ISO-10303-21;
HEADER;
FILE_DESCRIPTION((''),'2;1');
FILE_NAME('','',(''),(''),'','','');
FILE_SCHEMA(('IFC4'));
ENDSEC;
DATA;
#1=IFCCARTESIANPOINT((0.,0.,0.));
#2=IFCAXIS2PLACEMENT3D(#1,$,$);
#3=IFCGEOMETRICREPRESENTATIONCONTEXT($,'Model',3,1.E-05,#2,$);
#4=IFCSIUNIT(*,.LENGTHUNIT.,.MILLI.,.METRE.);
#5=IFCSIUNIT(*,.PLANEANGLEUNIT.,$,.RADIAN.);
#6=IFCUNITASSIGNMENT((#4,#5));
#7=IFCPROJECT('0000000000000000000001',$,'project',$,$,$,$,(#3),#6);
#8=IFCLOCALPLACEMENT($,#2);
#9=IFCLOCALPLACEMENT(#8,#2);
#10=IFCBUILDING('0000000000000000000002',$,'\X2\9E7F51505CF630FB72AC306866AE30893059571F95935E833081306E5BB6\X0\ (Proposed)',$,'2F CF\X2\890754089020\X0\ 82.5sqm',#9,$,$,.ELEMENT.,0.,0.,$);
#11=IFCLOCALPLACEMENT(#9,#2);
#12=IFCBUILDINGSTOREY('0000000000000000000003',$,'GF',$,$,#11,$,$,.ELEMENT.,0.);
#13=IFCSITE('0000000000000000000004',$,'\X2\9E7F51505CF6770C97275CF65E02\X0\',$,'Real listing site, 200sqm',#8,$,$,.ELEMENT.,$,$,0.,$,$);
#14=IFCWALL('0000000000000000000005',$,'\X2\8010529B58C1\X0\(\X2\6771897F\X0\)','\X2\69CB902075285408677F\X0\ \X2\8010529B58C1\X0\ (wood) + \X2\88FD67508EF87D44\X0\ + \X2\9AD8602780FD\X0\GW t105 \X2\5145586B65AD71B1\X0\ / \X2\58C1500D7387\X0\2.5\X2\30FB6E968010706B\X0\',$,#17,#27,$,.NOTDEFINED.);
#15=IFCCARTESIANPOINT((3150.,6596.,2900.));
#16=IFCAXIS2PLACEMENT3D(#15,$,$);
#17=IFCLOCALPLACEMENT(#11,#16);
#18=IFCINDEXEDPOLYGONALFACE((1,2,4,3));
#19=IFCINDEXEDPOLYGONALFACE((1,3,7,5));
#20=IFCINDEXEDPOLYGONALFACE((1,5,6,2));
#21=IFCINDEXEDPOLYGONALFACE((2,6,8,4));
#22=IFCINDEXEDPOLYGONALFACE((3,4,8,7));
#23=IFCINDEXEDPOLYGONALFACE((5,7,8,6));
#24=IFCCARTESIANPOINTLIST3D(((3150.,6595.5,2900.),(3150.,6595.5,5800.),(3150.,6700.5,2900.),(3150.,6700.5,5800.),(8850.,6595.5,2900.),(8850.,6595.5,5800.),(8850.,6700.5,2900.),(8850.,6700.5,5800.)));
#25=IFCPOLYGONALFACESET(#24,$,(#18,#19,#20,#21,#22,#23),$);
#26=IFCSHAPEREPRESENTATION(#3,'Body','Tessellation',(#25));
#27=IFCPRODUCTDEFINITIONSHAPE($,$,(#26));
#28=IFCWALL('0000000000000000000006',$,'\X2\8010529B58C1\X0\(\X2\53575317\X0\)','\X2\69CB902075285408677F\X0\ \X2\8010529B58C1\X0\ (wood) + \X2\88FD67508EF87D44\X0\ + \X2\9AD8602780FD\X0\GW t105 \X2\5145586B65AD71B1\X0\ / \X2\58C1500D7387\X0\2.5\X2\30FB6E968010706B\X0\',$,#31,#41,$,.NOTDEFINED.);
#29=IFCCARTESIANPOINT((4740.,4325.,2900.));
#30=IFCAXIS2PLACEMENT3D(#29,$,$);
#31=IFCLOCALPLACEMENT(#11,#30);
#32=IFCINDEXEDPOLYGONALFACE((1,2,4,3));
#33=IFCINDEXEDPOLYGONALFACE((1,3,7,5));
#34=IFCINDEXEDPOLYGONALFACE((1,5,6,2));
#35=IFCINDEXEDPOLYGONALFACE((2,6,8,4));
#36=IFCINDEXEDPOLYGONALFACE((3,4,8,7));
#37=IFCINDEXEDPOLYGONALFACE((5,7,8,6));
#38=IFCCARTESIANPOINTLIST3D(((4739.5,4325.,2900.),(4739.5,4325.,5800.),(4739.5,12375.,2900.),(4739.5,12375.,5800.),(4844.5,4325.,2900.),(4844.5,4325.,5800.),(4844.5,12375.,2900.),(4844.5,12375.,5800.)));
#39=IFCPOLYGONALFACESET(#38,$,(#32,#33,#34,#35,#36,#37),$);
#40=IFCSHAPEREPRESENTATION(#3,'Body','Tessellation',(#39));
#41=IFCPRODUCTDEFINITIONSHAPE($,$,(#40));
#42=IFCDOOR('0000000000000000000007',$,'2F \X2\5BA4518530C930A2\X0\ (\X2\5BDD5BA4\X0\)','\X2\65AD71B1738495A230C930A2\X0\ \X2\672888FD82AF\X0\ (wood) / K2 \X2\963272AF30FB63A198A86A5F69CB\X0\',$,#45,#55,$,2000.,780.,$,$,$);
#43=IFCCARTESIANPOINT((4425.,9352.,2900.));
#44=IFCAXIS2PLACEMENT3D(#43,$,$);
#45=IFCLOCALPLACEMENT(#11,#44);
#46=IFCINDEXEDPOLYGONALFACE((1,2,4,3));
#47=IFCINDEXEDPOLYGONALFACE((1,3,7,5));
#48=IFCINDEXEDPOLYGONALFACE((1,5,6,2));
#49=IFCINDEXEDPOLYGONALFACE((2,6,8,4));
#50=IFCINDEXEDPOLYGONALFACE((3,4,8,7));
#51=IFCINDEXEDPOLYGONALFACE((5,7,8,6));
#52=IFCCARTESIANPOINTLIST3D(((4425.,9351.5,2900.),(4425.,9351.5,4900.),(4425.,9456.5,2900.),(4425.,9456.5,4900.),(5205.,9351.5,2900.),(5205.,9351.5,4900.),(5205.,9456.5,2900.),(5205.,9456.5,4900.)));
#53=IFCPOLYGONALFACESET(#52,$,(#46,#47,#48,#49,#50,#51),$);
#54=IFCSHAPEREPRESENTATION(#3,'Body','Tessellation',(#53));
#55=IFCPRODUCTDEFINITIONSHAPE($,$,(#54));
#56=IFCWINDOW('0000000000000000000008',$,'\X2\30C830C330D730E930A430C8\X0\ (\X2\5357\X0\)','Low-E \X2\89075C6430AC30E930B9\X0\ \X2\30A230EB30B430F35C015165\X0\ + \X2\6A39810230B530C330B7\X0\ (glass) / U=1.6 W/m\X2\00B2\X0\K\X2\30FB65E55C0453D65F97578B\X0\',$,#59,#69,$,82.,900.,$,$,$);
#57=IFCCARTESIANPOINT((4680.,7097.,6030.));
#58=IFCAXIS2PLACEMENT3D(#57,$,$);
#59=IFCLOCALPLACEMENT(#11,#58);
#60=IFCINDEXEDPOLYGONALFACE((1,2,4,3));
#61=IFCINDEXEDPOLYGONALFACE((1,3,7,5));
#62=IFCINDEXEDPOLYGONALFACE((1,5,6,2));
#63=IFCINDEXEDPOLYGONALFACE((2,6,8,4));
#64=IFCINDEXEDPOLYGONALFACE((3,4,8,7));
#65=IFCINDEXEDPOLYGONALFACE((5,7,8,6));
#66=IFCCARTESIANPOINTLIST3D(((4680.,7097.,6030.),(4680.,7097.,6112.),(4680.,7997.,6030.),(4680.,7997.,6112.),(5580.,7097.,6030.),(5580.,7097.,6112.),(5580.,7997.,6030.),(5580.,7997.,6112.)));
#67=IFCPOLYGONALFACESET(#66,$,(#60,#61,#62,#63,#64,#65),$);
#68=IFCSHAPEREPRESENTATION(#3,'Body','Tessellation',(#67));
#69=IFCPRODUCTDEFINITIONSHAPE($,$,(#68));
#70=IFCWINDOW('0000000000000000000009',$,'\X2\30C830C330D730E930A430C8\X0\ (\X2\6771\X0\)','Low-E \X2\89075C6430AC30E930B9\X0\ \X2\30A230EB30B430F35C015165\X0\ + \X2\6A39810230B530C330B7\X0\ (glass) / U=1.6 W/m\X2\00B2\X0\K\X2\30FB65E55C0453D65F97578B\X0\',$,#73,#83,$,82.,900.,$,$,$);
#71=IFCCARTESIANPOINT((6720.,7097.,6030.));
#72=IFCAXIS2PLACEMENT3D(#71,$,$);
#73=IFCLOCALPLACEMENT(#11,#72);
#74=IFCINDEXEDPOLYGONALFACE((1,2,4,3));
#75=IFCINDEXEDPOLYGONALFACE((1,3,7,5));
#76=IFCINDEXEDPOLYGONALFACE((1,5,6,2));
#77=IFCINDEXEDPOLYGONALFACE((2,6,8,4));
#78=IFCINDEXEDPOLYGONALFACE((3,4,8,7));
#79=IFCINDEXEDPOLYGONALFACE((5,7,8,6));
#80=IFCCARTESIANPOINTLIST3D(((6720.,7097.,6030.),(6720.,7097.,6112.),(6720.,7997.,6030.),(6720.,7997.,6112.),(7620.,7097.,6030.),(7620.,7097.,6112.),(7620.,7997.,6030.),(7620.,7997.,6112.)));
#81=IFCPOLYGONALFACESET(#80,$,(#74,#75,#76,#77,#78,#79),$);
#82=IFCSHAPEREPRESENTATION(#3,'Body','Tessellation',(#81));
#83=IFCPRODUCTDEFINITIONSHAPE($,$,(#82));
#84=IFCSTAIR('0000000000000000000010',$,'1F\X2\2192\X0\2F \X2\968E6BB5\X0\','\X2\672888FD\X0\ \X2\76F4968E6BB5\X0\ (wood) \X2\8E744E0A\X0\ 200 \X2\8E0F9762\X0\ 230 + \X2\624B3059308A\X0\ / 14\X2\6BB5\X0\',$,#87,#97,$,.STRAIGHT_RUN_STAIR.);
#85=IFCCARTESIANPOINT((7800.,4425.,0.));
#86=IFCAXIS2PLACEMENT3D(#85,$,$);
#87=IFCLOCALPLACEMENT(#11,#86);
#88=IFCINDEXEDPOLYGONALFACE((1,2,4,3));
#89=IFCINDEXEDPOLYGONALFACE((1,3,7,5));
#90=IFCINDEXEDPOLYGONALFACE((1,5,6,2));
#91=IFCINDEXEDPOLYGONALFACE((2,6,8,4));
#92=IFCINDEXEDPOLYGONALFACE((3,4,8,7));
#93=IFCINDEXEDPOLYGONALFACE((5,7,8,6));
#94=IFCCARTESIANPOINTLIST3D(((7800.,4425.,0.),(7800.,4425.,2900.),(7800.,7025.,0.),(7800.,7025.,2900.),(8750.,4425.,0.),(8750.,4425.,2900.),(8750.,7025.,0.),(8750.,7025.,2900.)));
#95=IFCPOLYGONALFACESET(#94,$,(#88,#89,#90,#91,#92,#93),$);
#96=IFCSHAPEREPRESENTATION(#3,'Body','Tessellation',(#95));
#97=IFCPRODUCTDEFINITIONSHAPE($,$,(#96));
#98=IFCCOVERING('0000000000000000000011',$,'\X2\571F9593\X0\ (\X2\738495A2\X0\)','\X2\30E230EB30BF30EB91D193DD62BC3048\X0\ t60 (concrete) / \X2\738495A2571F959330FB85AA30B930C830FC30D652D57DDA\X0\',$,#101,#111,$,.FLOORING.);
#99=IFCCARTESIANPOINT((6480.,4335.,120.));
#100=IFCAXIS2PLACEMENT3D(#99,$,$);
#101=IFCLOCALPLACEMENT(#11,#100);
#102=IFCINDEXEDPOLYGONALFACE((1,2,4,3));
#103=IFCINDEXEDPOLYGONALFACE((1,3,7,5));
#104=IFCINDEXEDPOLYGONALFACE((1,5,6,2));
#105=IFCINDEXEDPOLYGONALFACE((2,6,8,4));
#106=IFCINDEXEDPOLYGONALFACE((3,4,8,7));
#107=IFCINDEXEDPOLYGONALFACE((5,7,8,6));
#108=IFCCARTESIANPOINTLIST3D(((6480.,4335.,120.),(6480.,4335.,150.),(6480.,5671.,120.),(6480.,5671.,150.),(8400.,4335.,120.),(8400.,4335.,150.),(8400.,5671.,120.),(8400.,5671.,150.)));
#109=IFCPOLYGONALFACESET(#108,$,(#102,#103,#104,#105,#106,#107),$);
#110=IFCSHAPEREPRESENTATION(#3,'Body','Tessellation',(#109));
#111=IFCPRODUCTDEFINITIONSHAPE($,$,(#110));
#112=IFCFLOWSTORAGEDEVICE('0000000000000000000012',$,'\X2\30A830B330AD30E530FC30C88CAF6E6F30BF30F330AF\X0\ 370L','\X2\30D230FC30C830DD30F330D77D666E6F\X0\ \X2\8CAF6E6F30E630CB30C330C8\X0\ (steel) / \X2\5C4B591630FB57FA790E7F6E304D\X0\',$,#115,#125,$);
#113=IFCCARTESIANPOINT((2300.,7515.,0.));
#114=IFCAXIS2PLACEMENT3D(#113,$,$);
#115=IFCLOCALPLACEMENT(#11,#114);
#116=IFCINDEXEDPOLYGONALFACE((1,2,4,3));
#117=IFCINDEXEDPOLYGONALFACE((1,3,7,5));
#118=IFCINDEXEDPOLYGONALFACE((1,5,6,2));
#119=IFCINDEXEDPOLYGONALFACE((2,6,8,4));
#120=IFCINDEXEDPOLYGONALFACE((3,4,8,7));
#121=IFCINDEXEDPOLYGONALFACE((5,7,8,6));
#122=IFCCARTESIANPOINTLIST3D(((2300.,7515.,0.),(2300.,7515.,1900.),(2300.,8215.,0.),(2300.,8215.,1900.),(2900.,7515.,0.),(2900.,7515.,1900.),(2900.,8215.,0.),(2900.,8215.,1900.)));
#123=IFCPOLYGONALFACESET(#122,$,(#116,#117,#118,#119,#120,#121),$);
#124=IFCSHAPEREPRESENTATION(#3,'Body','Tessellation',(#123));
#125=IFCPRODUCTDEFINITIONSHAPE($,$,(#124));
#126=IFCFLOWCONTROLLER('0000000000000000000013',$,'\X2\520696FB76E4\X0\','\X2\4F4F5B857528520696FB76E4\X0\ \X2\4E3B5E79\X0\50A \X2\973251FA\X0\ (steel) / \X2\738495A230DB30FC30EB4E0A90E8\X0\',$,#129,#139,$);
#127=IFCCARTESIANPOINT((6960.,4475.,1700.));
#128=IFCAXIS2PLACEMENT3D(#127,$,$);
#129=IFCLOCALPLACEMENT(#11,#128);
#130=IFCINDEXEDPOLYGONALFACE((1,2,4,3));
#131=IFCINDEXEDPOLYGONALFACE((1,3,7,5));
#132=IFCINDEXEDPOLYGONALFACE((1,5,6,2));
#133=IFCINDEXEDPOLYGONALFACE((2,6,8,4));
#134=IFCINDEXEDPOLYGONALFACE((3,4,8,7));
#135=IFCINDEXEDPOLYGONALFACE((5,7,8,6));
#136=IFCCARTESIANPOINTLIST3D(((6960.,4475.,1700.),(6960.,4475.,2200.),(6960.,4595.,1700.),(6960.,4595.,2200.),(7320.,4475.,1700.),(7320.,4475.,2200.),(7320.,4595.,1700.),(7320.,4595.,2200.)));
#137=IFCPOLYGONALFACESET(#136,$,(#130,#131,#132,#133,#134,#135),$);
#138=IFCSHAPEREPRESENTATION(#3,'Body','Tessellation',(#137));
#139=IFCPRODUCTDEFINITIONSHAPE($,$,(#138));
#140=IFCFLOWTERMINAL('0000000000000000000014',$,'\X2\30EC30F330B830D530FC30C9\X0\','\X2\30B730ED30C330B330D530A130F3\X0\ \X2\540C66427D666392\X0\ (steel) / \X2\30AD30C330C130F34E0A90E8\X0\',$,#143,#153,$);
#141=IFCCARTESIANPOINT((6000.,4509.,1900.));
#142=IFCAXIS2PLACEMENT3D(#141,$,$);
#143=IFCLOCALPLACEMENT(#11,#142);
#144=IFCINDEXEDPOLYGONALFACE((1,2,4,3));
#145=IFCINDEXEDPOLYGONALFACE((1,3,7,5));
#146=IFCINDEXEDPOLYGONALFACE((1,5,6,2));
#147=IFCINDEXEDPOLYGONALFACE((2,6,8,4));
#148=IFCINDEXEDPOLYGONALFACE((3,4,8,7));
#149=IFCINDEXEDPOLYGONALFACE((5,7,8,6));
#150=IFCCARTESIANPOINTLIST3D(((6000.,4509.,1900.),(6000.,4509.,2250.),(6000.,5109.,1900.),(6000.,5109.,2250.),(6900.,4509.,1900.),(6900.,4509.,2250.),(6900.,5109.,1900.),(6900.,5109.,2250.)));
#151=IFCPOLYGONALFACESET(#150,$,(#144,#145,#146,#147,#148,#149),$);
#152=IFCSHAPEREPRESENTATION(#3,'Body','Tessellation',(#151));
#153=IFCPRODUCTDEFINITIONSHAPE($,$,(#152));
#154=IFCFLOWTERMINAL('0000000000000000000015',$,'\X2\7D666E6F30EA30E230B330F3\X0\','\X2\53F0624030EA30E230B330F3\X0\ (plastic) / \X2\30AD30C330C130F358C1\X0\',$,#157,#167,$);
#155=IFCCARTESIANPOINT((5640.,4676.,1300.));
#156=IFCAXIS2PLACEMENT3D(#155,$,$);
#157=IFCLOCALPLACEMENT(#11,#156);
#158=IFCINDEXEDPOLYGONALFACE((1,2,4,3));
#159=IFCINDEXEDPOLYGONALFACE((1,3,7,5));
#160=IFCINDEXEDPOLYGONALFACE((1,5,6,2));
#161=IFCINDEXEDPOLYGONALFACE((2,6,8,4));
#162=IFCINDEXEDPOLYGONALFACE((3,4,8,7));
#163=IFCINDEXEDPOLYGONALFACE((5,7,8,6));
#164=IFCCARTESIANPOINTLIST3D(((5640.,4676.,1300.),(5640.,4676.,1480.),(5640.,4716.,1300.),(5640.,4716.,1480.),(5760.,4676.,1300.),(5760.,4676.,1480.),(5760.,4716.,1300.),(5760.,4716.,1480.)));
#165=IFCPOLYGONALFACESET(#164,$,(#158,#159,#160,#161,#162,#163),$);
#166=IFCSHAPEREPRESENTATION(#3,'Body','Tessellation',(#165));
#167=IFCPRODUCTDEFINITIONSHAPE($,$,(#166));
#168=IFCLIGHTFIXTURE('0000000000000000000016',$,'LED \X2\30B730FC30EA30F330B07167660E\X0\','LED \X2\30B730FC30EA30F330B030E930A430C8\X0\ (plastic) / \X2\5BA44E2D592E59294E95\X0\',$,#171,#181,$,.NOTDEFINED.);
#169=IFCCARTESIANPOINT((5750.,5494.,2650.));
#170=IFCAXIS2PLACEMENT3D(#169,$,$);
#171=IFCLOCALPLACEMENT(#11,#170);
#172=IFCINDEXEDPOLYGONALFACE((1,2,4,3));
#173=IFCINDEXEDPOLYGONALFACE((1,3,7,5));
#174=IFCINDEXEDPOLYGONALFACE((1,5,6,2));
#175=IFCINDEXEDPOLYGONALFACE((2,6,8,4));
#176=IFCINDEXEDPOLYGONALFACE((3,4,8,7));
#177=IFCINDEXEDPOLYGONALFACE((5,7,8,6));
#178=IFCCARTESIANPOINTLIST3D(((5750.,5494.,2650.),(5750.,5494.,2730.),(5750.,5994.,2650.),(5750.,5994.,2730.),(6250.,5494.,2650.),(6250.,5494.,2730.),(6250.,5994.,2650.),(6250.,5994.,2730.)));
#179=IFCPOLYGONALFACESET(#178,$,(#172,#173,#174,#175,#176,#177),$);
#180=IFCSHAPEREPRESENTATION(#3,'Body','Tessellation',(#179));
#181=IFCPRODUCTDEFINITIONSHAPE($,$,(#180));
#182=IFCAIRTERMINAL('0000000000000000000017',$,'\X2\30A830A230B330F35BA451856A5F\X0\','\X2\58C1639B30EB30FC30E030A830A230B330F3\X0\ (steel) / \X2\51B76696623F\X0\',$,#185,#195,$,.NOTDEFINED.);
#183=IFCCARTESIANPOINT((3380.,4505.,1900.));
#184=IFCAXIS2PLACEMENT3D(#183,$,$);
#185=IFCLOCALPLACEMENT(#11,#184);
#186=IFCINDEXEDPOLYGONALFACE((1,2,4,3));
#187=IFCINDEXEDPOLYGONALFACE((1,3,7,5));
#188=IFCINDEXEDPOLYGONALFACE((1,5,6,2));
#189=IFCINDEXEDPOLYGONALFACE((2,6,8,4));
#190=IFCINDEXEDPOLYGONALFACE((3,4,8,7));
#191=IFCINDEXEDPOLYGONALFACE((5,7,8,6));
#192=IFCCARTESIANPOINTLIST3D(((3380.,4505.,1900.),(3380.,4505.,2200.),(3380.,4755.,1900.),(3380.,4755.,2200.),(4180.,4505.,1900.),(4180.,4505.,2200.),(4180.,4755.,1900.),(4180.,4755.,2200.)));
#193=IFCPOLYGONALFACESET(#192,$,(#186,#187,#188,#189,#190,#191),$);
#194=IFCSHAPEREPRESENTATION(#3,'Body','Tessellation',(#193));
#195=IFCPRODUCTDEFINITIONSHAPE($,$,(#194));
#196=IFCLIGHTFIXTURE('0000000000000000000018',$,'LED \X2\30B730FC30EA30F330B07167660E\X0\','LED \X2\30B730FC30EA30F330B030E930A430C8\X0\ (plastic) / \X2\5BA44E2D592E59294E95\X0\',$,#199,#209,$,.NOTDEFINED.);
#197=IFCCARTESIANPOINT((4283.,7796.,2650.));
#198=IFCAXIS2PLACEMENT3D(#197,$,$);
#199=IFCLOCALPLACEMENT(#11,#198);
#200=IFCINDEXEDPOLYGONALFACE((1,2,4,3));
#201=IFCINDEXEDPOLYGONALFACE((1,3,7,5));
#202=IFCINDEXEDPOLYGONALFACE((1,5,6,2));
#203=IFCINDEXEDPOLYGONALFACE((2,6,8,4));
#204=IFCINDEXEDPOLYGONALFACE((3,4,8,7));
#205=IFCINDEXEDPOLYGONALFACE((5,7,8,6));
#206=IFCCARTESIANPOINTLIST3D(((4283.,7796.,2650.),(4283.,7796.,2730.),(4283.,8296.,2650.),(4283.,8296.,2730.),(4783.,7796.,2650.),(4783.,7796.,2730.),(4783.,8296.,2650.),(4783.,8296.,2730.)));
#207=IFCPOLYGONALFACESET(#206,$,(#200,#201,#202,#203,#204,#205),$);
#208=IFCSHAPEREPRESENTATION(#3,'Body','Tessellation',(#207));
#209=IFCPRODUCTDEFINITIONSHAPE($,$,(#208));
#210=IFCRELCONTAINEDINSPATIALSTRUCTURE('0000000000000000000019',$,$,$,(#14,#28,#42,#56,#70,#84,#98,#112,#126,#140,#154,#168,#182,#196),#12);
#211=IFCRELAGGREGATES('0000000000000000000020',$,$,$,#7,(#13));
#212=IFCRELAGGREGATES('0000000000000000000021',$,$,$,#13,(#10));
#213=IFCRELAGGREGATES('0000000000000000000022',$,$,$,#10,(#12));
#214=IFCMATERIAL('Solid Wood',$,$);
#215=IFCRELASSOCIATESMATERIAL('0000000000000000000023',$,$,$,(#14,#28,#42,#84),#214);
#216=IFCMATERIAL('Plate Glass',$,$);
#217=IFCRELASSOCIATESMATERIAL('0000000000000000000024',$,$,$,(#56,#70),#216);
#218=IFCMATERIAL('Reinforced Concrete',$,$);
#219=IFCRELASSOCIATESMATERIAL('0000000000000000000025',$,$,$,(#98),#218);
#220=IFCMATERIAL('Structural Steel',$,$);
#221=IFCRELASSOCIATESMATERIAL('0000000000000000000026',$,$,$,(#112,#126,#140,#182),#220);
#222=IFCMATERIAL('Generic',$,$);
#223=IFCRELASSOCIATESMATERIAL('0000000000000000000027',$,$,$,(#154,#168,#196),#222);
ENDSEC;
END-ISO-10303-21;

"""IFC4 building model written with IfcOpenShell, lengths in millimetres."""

from ifc_helpers import new_model, si_unit, frame, frame_2d, origin, place, context, project, spatial, rectangle, extrude, material, element, fill, save


model = new_model("IFC4")

# Units and contexts
model_context = context("Model", 3, precision=1e-05, world=origin())
ifc_project = project(units=[si_unit("LENGTHUNIT", "METRE", prefix="MILLI"), si_unit("PLANEANGLEUNIT", "RADIAN")], contexts=[model_context])

# Site, building, storey
site_placement = place(None, origin())
site = spatial("IfcSite", under=ifc_project, at=site_placement, Name="鹿児島県霧島市", ObjectType="Real listing site, 200sqm", CompositionType="ELEMENT", RefElevation=0.0)
building_placement = place(site_placement, origin())
building = spatial("IfcBuilding", under=site, at=building_placement, Name="鹿児島・犬と暮らす土間広めの家 (Proposed)", ObjectType="2F CF複合造 82.5sqm", CompositionType="ELEMENT", ElevationOfRefHeight=0.0, ElevationOfTerrain=0.0)
storey_placement = place(building_placement, origin())
storey = spatial("IfcBuildingStorey", under=building, at=storey_placement, Name="GF", CompositionType="ELEMENT", Elevation=0.0)

# Shared definitions
ifc_material_1 = material(Name="Solid Wood")

# Wall
wall_1_placement = place(storey_placement, frame((3150.0, 6596.0, 2900.0)))
element("IfcWall", 1, at=wall_1_placement, inside=storey, material=ifc_material_1, Name="耐力壁(東西)", Description="構造用合板 耐力壁 (wood) + 製材軸組 + 高性能GW t105 充填断熱 / 壁倍率2.5・準耐火", PredefinedType="NOTDEFINED", context=model_context, shape_type="SweptSolid", body=[
    extrude(rectangle(XDim=5700.0, YDim=105.0, at=frame_2d((2850.0, 52.0))), frame((3150.0, 6596.0, 2900.0)), (0.0, 0.0, 1.0), 2900.0),
])

# Wall, opening, door
wall_2_placement = place(storey_placement, frame((4740.0, 4325.0, 2900.0)))
wall_2 = element("IfcWall", 2, at=wall_2_placement, inside=storey, material=ifc_material_1, Name="耐力壁(南北)", Description="構造用合板 耐力壁 (wood) + 製材軸組 + 高性能GW t105 充填断熱 / 壁倍率2.5・準耐火", PredefinedType="NOTDEFINED", context=model_context, shape_type="SweptSolid", body=[
    extrude(rectangle(XDim=105.0, YDim=8050.0, at=frame_2d((52.0, 4025.0))), frame((4740.0, 4325.0, 2900.0)), (0.0, 0.0, 1.0), 2900.0),
])
opening_placement = place(storey_placement, frame((4425.0, 9352.0, 2900.0)))
opening = element("IfcOpeningElement", 3, at=opening_placement, cuts=wall_2, PredefinedType="NOTDEFINED", context=model_context, shape_type="SweptSolid", body=[
    extrude(rectangle(XDim=780.0, YDim=105.0, at=frame_2d((390.0, 52.0))), frame((4425.0, 9352.0, 2900.0)), (0.0, 0.0, 1.0), 2000.0),
])
door_placement = place(storey_placement, frame((4425.0, 9352.0, 2900.0)))
door = element("IfcDoor", 4, at=door_placement, inside=storey, material=ifc_material_1, Name="2F 室内ドア (寝室)", Description="断熱玄関ドア 木製芯 (wood) / K2 防犯・採風機構", OverallHeight=2000.0, OverallWidth=780.0, context=model_context, shape_type="SweptSolid", body=[
    extrude(rectangle(XDim=780.0, YDim=105.0, at=frame_2d((390.0, 52.0))), frame((4425.0, 9352.0, 2900.0)), (0.0, 0.0, 1.0), 2000.0),
])
fill(opening, door)

# Windows
ifc_material_2 = material(Name="Plate Glass")
window_1_placement = place(storey_placement, frame((4680.0, 7097.0, 6030.0)))
element("IfcWindow", 5, at=window_1_placement, inside=storey, material=ifc_material_2, Name="トップライト (南)", Description="Low-E 複層ガラス アルゴン封入 + 樹脂サッシ (glass) / U=1.6 W/m²K・日射取得型", OverallHeight=82.0, OverallWidth=900.0, context=model_context, shape_type="SweptSolid", body=[
    extrude(rectangle(XDim=900.0, YDim=900.0, at=frame_2d((450.0, 450.0))), frame((4680.0, 7097.0, 6030.0)), (0.0, 0.0, 1.0), 82.0),
])
window_2_placement = place(storey_placement, frame((6720.0, 7097.0, 6030.0)))
element("IfcWindow", 6, at=window_2_placement, inside=storey, material=ifc_material_2, Name="トップライト (東)", Description="Low-E 複層ガラス アルゴン封入 + 樹脂サッシ (glass) / U=1.6 W/m²K・日射取得型", OverallHeight=82.0, OverallWidth=900.0, context=model_context, shape_type="SweptSolid", body=[
    extrude(rectangle(XDim=900.0, YDim=900.0, at=frame_2d((450.0, 450.0))), frame((6720.0, 7097.0, 6030.0)), (0.0, 0.0, 1.0), 82.0),
])

# Stair
stair_placement = place(storey_placement, frame((7800.0, 4425.0, 0.0)))
element("IfcStair", 7, at=stair_placement, inside=storey, material=ifc_material_1, Name="1F→2F 階段", Description="木製 直階段 (wood) 蹴上 200 踏面 230 + 手すり / 14段", PredefinedType="STRAIGHT_RUN_STAIR", context=model_context, shape_type="SweptSolid", body=[
    extrude(rectangle(XDim=950.0, YDim=2600.0, at=frame_2d((475.0, 1300.0))), frame((7800.0, 4425.0, 0.0)), (0.0, 0.0, 1.0), 2900.0),
])

# Covering
ifc_material_3 = material(Name="Reinforced Concrete")
covering_placement = place(storey_placement, frame((6480.0, 4335.0, 120.0)))
element("IfcCovering", 8, at=covering_placement, inside=storey, material=ifc_material_3, Name="土間 (玄関)", Description="モルタル金鏝押え t60 (concrete) / 玄関土間・薪ストーブ動線", PredefinedType="FLOORING", context=model_context, shape_type="SweptSolid", body=[
    extrude(rectangle(XDim=1920.0, YDim=1336.0, at=frame_2d((960.0, 668.0))), frame((6480.0, 4335.0, 120.0)), (0.0, 0.0, 1.0), 30.0),
])

# Flow storage device
ifc_material_4 = material(Name="Structural Steel")
flow_storage_device_1_placement = place(storey_placement, frame((2300.0, 7515.0, 0.0)))
element("IfcFlowStorageDevice", 9, at=flow_storage_device_1_placement, inside=storey, material=ifc_material_4, Name="エコキュート貯湯タンク 370L", Description="ヒートポンプ給湯 貯湯ユニット (steel) / 屋外・基礎置き", context=model_context, shape_type="SweptSolid", body=[
    extrude(rectangle(XDim=600.0, YDim=700.0, at=frame_2d((300.0, 350.0))), frame((2300.0, 7515.0, 0.0)), (0.0, 0.0, 1.0), 1900.0),
])

# Flow controller
flow_controller_placement = place(storey_placement, frame((6960.0, 4475.0, 1700.0)))
element("IfcFlowController", 10, at=flow_controller_placement, inside=storey, material=ifc_material_4, Name="分電盤", Description="住宅用分電盤 主幹50A 露出 (steel) / 玄関ホール上部", context=model_context, shape_type="SweptSolid", body=[
    extrude(rectangle(XDim=360.0, YDim=120.0, at=frame_2d((180.0, 60.0))), frame((6960.0, 4475.0, 1700.0)), (0.0, 0.0, 1.0), 500.0),
])

# Flow terminals
flow_terminal_1_placement = place(storey_placement, frame((6000.0, 4509.0, 1900.0)))
element("IfcFlowTerminal", 11, at=flow_terminal_1_placement, inside=storey, material=ifc_material_4, Name="レンジフード", Description="シロッコファン 同時給排 (steel) / キッチン上部", context=model_context, shape_type="SweptSolid", body=[
    extrude(rectangle(XDim=900.0, YDim=600.0, at=frame_2d((450.0, 300.0))), frame((6000.0, 4509.0, 1900.0)), (0.0, 0.0, 1.0), 350.0),
])
ifc_material_5 = material(Name="Generic")
flow_terminal_2_placement = place(storey_placement, frame((5640.0, 4676.0, 1300.0)))
element("IfcFlowTerminal", 12, at=flow_terminal_2_placement, inside=storey, material=ifc_material_5, Name="給湯リモコン", Description="台所リモコン (plastic) / キッチン壁", context=model_context, shape_type="SweptSolid", body=[
    extrude(rectangle(XDim=120.0, YDim=40.0, at=frame_2d((60.0, 20.0))), frame((5640.0, 4676.0, 1300.0)), (0.0, 0.0, 1.0), 180.0),
])

# Light fixture
light_fixture_1_placement = place(storey_placement, frame((5750.0, 5494.0, 2650.0)))
element("IfcLightFixture", 13, at=light_fixture_1_placement, inside=storey, material=ifc_material_5, Name="LED シーリング照明", Description="LED シーリングライト (plastic) / 室中央天井", PredefinedType="NOTDEFINED", context=model_context, shape_type="SweptSolid", body=[
    extrude(rectangle(XDim=500.0, YDim=500.0, at=frame_2d((250.0, 250.0))), frame((5750.0, 5494.0, 2650.0)), (0.0, 0.0, 1.0), 80.0),
])

# Air terminal
air_terminal_1_placement = place(storey_placement, frame((3380.0, 4505.0, 1900.0)))
element("IfcAirTerminal", 14, at=air_terminal_1_placement, inside=storey, material=ifc_material_4, Name="エアコン室内機", Description="壁掛ルームエアコン (steel) / 冷暖房", PredefinedType="NOTDEFINED", context=model_context, shape_type="SweptSolid", body=[
    extrude(rectangle(XDim=800.0, YDim=250.0, at=frame_2d((400.0, 125.0))), frame((3380.0, 4505.0, 1900.0)), (0.0, 0.0, 1.0), 300.0),
])

# Light fixture
light_fixture_2_placement = place(storey_placement, frame((4283.0, 7796.0, 2650.0)))
element("IfcLightFixture", 15, at=light_fixture_2_placement, inside=storey, material=ifc_material_5, Name="LED シーリング照明", Description="LED シーリングライト (plastic) / 室中央天井", PredefinedType="NOTDEFINED", context=model_context, shape_type="SweptSolid", body=[
    extrude(rectangle(XDim=500.0, YDim=500.0, at=frame_2d((250.0, 250.0))), frame((4283.0, 7796.0, 2650.0)), (0.0, 0.0, 1.0), 80.0),
])

save(model, "model.ifc")
